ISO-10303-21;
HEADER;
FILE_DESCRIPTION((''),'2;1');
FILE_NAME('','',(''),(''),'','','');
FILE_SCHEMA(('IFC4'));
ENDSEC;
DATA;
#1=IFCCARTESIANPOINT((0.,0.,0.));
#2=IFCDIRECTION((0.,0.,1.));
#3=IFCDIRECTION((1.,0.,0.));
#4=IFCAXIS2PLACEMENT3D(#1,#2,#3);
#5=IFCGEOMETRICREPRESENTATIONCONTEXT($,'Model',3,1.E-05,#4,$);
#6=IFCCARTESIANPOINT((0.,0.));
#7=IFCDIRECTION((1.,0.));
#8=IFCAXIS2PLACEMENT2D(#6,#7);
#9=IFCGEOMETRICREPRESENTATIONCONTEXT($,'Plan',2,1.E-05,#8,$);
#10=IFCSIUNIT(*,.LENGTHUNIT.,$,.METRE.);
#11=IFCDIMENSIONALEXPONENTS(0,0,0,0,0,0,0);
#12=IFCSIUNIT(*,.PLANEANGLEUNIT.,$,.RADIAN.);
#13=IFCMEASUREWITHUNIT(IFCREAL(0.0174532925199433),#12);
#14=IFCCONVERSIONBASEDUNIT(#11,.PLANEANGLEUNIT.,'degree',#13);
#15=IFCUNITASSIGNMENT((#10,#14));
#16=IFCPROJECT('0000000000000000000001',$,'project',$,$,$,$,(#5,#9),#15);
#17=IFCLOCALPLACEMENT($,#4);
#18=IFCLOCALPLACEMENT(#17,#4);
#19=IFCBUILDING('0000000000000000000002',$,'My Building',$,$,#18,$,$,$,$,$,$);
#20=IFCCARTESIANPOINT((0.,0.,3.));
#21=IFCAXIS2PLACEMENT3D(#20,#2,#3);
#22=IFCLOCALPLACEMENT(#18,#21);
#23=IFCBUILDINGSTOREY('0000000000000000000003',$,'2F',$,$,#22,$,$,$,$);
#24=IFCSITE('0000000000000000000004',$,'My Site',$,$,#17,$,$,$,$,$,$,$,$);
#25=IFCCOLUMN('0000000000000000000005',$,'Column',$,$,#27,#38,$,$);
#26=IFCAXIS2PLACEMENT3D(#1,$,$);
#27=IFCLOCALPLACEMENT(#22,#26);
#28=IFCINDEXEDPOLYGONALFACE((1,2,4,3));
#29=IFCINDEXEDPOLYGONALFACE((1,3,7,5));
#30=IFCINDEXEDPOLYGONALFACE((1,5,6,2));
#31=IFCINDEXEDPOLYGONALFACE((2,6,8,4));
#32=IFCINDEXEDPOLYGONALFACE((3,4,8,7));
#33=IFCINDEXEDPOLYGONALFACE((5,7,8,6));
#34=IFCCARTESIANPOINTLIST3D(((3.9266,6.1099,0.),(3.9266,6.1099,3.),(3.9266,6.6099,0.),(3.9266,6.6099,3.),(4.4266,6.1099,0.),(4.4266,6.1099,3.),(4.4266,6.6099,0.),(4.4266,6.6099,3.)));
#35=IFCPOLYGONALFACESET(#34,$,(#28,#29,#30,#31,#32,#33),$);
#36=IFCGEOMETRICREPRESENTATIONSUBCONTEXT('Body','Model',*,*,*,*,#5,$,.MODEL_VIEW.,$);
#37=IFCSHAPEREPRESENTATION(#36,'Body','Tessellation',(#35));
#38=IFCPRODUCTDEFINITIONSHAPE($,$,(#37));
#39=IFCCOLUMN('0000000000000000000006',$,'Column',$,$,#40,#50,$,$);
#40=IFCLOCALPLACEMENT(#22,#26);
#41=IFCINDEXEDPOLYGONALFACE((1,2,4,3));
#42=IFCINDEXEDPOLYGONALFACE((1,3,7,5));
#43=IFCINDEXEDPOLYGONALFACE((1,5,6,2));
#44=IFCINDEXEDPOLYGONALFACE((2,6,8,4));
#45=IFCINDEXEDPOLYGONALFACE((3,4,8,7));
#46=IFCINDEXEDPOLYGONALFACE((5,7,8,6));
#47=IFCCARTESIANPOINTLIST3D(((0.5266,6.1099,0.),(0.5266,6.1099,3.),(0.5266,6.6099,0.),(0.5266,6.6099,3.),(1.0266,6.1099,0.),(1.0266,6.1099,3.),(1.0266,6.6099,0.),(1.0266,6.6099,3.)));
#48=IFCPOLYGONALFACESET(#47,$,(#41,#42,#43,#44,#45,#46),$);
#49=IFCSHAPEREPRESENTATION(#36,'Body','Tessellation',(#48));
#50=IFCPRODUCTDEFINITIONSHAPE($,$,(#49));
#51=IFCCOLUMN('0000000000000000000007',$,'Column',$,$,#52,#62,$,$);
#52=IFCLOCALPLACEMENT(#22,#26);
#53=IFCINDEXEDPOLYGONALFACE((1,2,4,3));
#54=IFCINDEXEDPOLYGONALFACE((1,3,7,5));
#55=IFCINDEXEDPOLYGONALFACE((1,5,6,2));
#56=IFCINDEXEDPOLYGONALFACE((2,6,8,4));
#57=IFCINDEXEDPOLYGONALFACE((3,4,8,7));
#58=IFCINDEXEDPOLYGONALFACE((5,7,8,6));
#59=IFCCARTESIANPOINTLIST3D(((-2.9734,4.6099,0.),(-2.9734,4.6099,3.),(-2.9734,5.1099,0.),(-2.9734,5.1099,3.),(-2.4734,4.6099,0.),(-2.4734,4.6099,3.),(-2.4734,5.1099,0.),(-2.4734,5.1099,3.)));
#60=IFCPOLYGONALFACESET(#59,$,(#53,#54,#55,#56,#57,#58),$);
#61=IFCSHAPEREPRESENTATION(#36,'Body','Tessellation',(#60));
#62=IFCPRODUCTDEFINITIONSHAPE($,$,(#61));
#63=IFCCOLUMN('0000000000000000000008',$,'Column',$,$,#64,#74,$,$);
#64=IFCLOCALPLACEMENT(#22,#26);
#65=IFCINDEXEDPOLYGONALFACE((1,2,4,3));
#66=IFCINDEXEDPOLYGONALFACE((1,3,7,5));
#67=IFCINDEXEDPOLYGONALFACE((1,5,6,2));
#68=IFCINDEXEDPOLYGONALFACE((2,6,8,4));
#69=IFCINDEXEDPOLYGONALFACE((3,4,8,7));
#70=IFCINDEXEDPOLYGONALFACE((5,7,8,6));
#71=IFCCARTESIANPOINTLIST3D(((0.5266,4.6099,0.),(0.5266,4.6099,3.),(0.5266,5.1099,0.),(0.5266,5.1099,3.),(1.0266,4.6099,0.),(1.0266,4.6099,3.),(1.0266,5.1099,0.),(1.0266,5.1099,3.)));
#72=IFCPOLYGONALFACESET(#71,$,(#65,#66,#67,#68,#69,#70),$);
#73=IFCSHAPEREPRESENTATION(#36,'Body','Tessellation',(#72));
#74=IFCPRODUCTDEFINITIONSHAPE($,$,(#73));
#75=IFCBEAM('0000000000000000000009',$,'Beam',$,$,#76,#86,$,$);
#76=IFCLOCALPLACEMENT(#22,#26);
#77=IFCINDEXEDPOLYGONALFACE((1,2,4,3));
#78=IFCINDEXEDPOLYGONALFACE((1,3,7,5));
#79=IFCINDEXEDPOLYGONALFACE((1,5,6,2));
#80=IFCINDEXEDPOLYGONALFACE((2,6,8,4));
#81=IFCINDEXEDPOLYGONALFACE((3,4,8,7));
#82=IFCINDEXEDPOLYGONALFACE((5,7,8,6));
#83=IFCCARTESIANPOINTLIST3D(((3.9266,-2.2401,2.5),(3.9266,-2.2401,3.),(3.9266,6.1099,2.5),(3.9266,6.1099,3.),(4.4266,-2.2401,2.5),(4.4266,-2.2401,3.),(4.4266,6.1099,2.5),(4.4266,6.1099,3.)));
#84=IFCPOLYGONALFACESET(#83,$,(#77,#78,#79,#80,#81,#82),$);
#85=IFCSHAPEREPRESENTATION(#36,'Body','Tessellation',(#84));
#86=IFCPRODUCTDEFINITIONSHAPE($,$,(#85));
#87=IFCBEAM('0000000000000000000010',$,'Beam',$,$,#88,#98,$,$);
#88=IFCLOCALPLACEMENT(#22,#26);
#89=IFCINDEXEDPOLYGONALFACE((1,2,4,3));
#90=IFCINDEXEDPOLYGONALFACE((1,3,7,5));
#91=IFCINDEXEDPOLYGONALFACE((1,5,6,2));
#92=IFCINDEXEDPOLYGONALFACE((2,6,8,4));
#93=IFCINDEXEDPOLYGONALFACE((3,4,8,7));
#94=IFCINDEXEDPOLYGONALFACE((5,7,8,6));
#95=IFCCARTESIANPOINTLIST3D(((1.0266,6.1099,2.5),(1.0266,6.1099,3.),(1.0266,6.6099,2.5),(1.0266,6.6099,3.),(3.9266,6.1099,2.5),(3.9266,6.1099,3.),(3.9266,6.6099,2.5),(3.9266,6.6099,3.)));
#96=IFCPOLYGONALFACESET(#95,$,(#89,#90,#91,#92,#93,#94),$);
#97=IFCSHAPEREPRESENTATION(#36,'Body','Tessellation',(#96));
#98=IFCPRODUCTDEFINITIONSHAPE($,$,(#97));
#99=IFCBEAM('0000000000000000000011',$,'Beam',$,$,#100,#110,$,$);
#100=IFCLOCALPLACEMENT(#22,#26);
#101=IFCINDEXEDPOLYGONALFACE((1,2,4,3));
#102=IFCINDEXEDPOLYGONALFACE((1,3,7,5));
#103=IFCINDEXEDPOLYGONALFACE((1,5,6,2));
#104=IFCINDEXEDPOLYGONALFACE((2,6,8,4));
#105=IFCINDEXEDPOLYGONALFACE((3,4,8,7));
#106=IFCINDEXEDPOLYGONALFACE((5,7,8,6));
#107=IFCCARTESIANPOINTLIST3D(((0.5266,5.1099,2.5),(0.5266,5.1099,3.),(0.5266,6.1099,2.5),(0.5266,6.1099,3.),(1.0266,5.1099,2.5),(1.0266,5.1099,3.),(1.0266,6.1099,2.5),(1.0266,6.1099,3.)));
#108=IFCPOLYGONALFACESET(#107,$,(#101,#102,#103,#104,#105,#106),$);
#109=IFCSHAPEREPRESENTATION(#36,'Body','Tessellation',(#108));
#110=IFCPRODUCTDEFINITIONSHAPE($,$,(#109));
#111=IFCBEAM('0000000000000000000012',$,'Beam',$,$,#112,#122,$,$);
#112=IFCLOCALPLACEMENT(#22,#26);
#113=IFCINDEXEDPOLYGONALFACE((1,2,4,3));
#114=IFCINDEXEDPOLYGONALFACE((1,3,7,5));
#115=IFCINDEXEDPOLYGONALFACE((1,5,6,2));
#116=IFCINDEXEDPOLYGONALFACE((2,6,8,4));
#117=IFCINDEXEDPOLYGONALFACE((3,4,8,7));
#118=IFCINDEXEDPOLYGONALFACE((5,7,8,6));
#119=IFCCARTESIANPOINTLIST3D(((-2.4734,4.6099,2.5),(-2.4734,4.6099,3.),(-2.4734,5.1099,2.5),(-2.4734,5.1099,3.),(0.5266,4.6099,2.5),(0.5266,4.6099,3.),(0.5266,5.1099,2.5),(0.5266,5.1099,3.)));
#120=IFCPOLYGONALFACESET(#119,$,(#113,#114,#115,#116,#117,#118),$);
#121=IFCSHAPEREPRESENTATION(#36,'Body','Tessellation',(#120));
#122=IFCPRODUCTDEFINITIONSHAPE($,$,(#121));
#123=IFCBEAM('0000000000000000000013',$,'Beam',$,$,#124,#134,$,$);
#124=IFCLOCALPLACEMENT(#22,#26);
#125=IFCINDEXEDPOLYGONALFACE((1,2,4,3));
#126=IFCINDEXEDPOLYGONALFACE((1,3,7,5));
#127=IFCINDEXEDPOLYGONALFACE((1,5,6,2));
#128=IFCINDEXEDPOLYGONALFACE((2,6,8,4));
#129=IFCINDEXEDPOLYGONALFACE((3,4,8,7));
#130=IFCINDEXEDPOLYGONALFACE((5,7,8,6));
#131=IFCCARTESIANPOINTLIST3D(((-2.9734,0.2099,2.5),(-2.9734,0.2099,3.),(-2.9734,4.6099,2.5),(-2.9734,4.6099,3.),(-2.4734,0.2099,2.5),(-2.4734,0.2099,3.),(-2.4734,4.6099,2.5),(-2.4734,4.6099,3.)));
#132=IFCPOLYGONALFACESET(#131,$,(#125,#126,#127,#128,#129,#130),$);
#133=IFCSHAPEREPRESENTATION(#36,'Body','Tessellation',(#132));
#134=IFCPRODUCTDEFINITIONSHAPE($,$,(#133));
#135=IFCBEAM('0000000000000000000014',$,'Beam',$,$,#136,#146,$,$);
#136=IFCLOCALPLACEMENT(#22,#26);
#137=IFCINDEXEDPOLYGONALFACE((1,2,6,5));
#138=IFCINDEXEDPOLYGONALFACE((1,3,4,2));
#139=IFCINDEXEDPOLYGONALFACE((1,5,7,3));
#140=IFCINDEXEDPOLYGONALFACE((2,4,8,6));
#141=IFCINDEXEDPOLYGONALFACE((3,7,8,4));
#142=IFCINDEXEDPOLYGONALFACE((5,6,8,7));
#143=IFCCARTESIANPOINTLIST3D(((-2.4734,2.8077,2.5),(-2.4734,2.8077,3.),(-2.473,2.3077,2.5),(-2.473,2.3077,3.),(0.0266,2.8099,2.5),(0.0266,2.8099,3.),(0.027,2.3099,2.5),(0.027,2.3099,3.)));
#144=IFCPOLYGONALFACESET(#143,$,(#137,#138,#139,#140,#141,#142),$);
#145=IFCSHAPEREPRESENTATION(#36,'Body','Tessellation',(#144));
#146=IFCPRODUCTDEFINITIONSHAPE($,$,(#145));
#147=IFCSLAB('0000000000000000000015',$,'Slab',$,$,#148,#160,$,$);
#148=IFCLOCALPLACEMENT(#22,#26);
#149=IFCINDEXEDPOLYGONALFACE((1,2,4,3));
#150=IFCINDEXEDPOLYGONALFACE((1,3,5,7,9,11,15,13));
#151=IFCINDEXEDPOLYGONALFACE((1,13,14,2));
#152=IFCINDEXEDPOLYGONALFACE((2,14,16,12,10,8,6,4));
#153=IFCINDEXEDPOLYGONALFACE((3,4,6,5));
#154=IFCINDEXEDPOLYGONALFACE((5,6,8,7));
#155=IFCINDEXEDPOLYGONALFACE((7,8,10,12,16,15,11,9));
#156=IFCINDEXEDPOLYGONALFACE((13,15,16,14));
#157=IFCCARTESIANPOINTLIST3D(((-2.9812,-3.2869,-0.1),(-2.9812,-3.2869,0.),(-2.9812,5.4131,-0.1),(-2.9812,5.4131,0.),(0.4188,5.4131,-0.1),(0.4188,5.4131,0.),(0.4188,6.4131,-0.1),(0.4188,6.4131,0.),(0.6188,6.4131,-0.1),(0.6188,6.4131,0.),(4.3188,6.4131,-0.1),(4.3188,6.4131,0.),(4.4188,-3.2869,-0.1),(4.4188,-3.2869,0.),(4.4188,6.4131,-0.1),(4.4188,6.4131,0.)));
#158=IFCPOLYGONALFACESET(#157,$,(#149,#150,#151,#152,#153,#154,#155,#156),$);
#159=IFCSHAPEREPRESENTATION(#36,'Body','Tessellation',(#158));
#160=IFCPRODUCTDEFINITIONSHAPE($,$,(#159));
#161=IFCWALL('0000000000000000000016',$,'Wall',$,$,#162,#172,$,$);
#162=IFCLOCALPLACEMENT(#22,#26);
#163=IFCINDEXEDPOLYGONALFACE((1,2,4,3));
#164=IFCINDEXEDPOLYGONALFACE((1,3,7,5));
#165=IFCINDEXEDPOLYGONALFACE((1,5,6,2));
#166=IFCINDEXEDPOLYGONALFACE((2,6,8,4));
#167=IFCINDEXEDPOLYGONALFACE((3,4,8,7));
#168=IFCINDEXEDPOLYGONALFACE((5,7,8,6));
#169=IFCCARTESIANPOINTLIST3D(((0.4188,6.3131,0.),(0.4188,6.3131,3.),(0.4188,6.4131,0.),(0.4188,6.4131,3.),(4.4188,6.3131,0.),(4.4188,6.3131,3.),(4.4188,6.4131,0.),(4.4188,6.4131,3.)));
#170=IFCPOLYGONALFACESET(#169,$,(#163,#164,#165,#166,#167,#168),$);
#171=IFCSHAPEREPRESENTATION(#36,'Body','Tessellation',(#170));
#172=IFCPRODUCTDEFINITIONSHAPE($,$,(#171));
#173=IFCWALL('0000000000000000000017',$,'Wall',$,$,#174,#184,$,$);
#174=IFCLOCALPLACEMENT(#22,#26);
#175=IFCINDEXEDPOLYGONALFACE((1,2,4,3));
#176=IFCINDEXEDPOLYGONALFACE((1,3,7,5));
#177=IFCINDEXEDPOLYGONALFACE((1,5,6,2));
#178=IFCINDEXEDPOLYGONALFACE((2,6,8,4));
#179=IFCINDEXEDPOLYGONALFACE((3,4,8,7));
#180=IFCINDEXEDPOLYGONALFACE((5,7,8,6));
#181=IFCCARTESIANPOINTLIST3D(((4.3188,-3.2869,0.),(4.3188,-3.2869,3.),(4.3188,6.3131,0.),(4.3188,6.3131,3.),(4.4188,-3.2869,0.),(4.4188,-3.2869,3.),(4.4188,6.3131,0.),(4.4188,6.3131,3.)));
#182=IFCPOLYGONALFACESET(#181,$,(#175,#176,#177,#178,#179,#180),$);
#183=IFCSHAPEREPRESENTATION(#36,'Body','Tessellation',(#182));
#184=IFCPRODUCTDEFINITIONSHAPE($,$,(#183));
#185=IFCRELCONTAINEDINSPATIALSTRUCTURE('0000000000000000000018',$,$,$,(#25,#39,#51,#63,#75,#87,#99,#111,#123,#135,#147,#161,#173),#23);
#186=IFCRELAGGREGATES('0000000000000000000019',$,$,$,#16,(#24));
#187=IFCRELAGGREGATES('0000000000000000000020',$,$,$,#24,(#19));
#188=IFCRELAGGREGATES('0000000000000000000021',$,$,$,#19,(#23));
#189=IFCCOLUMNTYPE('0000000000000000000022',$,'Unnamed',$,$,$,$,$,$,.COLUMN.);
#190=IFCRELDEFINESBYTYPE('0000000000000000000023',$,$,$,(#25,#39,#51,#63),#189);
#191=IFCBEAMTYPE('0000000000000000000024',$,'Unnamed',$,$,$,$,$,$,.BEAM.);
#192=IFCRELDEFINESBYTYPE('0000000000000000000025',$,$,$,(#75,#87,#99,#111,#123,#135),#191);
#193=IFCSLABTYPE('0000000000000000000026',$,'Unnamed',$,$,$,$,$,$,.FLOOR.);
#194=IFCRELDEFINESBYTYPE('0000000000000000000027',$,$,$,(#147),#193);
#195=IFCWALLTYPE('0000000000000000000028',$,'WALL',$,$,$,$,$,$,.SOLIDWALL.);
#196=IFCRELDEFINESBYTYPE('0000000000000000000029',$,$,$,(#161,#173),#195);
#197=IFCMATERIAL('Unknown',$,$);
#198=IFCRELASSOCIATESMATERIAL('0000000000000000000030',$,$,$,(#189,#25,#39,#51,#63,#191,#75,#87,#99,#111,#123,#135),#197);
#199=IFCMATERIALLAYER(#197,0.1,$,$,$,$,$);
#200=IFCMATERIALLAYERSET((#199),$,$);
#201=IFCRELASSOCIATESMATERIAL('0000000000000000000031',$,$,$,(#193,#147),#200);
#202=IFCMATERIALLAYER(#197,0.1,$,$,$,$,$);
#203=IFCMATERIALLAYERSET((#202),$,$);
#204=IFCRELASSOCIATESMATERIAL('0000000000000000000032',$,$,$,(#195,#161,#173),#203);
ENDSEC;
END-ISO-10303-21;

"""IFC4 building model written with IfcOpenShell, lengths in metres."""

from ifc_helpers import new_model, entity, si_unit, converted_unit, frame, origin_with_axes, origin_2d_with_axis, place, context, subcontext, project, spatial, line, indexed_curve, rectangle, outline, extrude, material, layer, layer_set, layer_usage, material_profile, profile_set, profile_usage, type_object, element, save


model = new_model("IFC4")

# Units and contexts
model_context = context("Model", 3, precision=1e-05, world=origin_with_axes())
plan_context = context("Plan", 2, precision=1e-05, world=origin_2d_with_axis())
body_context_1 = subcontext(model_context, "Body", "Model", "MODEL_VIEW")
ifc_project = project(units=[si_unit("LENGTHUNIT", "METRE"), converted_unit("PLANEANGLEUNIT", "degree", entity("IfcReal", 0.0174532925199433), si_unit("PLANEANGLEUNIT", "RADIAN"), dimensions=[0, 0, 0, 0, 0, 0, 0])], contexts=[model_context, plan_context])

# Site, building, storey
site_placement = place(None, origin_with_axes())
site = spatial("IfcSite", under=ifc_project, at=site_placement, Name="My Site")
building_placement = place(site_placement, origin_with_axes())
building = spatial("IfcBuilding", under=site, at=building_placement, Name="My Building")
storey_placement = place(building_placement, frame((0.0, 0.0, 3.0), z_axis=(0.0, 0.0, 1.0), x_axis=(1.0, 0.0, 0.0)))
storey = spatial("IfcBuildingStorey", under=building, at=storey_placement, Name="2F")

# Columns
ifc_material = material(Name="Unknown")
ifc_material_profile_1 = material_profile(ifc_material, rectangle(XDim=0.5, YDim=0.5))
ifc_profile_set_1 = profile_set([ifc_material_profile_1])
ifc_profile_usage_1 = profile_usage(ifc_profile_set_1, cardinal=5)
column_type = type_object("IfcColumnType", Name="Unnamed", PredefinedType="COLUMN", material=ifc_profile_set_1)
column_1_placement = place(storey_placement, frame((4.1766, 6.3599, 0.0), z_axis=(0.0, 0.0, 1.0), x_axis=(1.0, 0.0, 0.0)))
element("IfcColumn", 1, at=column_1_placement, inside=storey, type_object=column_type, material=ifc_profile_usage_1, Name="Column", context=body_context_1, shape_type="SweptSolid", body=[
    extrude(rectangle(XDim=0.5, YDim=0.5), origin_with_axes(), (0.0, 0.0, 1.0), 3.0),
])
ifc_profile_usage_2 = profile_usage(ifc_profile_set_1, cardinal=5)
column_2_placement = place(storey_placement, frame((0.7766, 6.3599, 0.0), z_axis=(0.0, 0.0, 1.0), x_axis=(1.0, 0.0, 0.0)))
element("IfcColumn", 2, at=column_2_placement, inside=storey, type_object=column_type, material=ifc_profile_usage_2, Name="Column", context=body_context_1, shape_type="SweptSolid", body=[
    extrude(rectangle(XDim=0.5, YDim=0.5), origin_with_axes(), (0.0, 0.0, 1.0), 3.0),
])
ifc_profile_usage_3 = profile_usage(ifc_profile_set_1, cardinal=5)
column_3_placement = place(storey_placement, frame((-2.7234, 4.8599, 0.0), z_axis=(0.0, 0.0, 1.0), x_axis=(1.0, 0.0, 0.0)))
element("IfcColumn", 3, at=column_3_placement, inside=storey, type_object=column_type, material=ifc_profile_usage_3, Name="Column", context=body_context_1, shape_type="SweptSolid", body=[
    extrude(rectangle(XDim=0.5, YDim=0.5), origin_with_axes(), (0.0, 0.0, 1.0), 3.0),
])
ifc_profile_usage_4 = profile_usage(ifc_profile_set_1, cardinal=5)
column_4_placement = place(storey_placement, frame((0.7766, 4.8599, 0.0), z_axis=(0.0, 0.0, 1.0), x_axis=(1.0, 0.0, 0.0)))
element("IfcColumn", 4, at=column_4_placement, inside=storey, type_object=column_type, material=ifc_profile_usage_4, Name="Column", context=body_context_1, shape_type="SweptSolid", body=[
    extrude(rectangle(XDim=0.5, YDim=0.5), origin_with_axes(), (0.0, 0.0, 1.0), 3.0),
])

# Beams
ifc_material_profile_2 = material_profile(ifc_material, rectangle(XDim=0.5, YDim=0.5))
ifc_profile_set_2 = profile_set([ifc_material_profile_2])
ifc_profile_usage_5 = profile_usage(ifc_profile_set_2, cardinal=9)
beam_type = type_object("IfcBeamType", Name="Unnamed", PredefinedType="BEAM", material=ifc_profile_set_2)
beam_1_placement = place(storey_placement, frame((3.9266, 6.1099, 3.0), z_axis=(0.0, -1.0, 0.0), x_axis=(1.0, 0.0, 0.0)))
element("IfcBeam", 5, at=beam_1_placement, inside=storey, type_object=beam_type, material=ifc_profile_usage_5, Name="Beam", context=body_context_1, shape_type="SweptSolid", body=[
    extrude(rectangle(XDim=0.5, YDim=0.5), frame((0.25, -0.25, 0.0), z_axis=(0.0, 0.0, 1.0), x_axis=(1.0, 0.0, 0.0)), (0.0, 0.0, 1.0), 8.35),
])
ifc_profile_usage_6 = profile_usage(ifc_profile_set_2, cardinal=7)
beam_2_placement = place(storey_placement, frame((1.0266, 6.6099, 3.0), z_axis=(1.0, -0.000001, 0.0), x_axis=(0.000001, 1.0, 0.0)))
element("IfcBeam", 6, at=beam_2_placement, inside=storey, type_object=beam_type, material=ifc_profile_usage_6, Name="Beam", context=body_context_1, shape_type="SweptSolid", body=[
    extrude(rectangle(XDim=0.5, YDim=0.5), frame((-0.25, -0.25, 0.0), z_axis=(0.0, 0.0, 1.0), x_axis=(1.0, 0.0, 0.0)), (0.0, 0.0, 1.0), 2.9),
])
ifc_profile_usage_7 = profile_usage(ifc_profile_set_2, cardinal=7)
beam_3_placement = place(storey_placement, frame((1.0266, 6.1099, 3.0), z_axis=(0.0, -1.0, 0.0), x_axis=(1.0, 0.0, 0.0)))
element("IfcBeam", 7, at=beam_3_placement, inside=storey, type_object=beam_type, material=ifc_profile_usage_7, Name="Beam", context=body_context_1, shape_type="SweptSolid", body=[
    extrude(rectangle(XDim=0.5, YDim=0.5), frame((-0.25, -0.25, 0.0), z_axis=(0.0, 0.0, 1.0), x_axis=(1.0, 0.0, 0.0)), (0.0, 0.0, 1.0), 1.0),
])
ifc_profile_usage_8 = profile_usage(ifc_profile_set_2, cardinal=7)
beam_4_placement = place(storey_placement, frame((-2.4734, 5.1099, 3.0), z_axis=(1.0, -0.000001, 0.0), x_axis=(0.000001, 1.0, 0.0)))
element("IfcBeam", 8, at=beam_4_placement, inside=storey, type_object=beam_type, material=ifc_profile_usage_8, Name="Beam", context=body_context_1, shape_type="SweptSolid", body=[
    extrude(rectangle(XDim=0.5, YDim=0.5), frame((-0.25, -0.25, 0.0), z_axis=(0.0, 0.0, 1.0), x_axis=(1.0, 0.0, 0.0)), (0.0, 0.0, 1.0), 3.0),
])
ifc_profile_usage_9 = profile_usage(ifc_profile_set_2, cardinal=7)
beam_5_placement = place(storey_placement, frame((-2.4734, 4.6099, 3.0), z_axis=(0.0, -1.0, 0.0), x_axis=(1.0, 0.0, 0.0)))
element("IfcBeam", 9, at=beam_5_placement, inside=storey, type_object=beam_type, material=ifc_profile_usage_9, Name="Beam", context=body_context_1, shape_type="SweptSolid", body=[
    extrude(rectangle(XDim=0.5, YDim=0.5), frame((-0.25, -0.25, 0.0), z_axis=(0.0, 0.0, 1.0), x_axis=(1.0, 0.0, 0.0)), (0.0, 0.0, 1.0), 4.4),
])
ifc_profile_usage_10 = profile_usage(ifc_profile_set_2, cardinal=7)
beam_6_placement = place(storey_placement, frame((-2.4734, 2.8077, 3.0), z_axis=(1.0, 0.000853, 0.0), x_axis=(-0.000853, 1.0, 0.0)))
element("IfcBeam", 10, at=beam_6_placement, inside=storey, type_object=beam_type, material=ifc_profile_usage_10, Name="Beam", context=body_context_1, shape_type="SweptSolid", body=[
    extrude(rectangle(XDim=0.5, YDim=0.5), frame((-0.25, -0.25, 0.0), z_axis=(0.0, 0.0, 1.0), x_axis=(1.0, 0.0, 0.0)), (0.0, 0.0, 1.0), 2.5),
])

# Slab
ifc_layer_1 = layer(ifc_material, 0.1)
ifc_layer_set_1 = layer_set([ifc_layer_1])
ifc_layer_usage_1 = layer_usage(ifc_layer_set_1, "AXIS3", "POSITIVE", -0.1)
slab_type = type_object("IfcSlabType", Name="Unnamed", PredefinedType="FLOOR", material=ifc_layer_set_1)
slab_placement = place(storey_placement, frame((0.6188, 6.4131, 0.0), z_axis=(0.0, 0.0, 1.0), x_axis=(1.0, 0.0, 0.0)))
element("IfcSlab", 11, at=slab_placement, inside=storey, type_object=slab_type, material=ifc_layer_usage_1, Name="Slab", context=body_context_1, shape_type="SweptSolid", body=[
    extrude(outline(indexed_curve([(0.0, 0.0), (3.7, 0.0), (3.8, 0.0), (3.8, -9.7), (-3.6, -9.7), (-3.6, -1.0), (-0.2, -1.0), (-0.2, 0.0), (0.0, 0.0)])), frame((0.0, 0.0, -0.1), z_axis=(0.0, 0.0, 1.0), x_axis=(1.0, 0.0, 0.0)), (0.0, 0.0, 1.0), 0.1),
])

# Walls
ifc_layer_2 = layer(ifc_material, 0.1)
ifc_layer_set_2 = layer_set([ifc_layer_2])
ifc_layer_usage_2 = layer_usage(ifc_layer_set_2, "AXIS2", "POSITIVE", 0.0)
wall_type = type_object("IfcWallType", Name="WALL", PredefinedType="SOLIDWALL", material=ifc_layer_set_2)
wall_1_placement = place(storey_placement, frame((0.4188, 6.3131, 0.0), z_axis=(0.0, 0.0, 1.0), x_axis=(1.0, 0.0, 0.0)))
element("IfcWall", 12, at=wall_1_placement, inside=storey, type_object=wall_type, material=ifc_layer_usage_2, Name="Wall", context=body_context_1, shape_type="SweptSolid", body=[
    extrude(outline(indexed_curve([(0.0, 0.0), (0.0, 0.1), (4.0, 0.1), (4.0, 0.0)], segments=[line(1, 2, 3, 4, 1)])), origin_with_axes(), (0.0, 0.0, 1.0), 3.0),
])
ifc_layer_usage_3 = layer_usage(ifc_layer_set_2, "AXIS2", "POSITIVE", 0.0)
wall_2_placement = place(storey_placement, frame((4.3188, 6.3131, 0.0), z_axis=(0.0, 0.0, 1.0), x_axis=(0.0, -1.0, 0.0)))
element("IfcWall", 13, at=wall_2_placement, inside=storey, type_object=wall_type, material=ifc_layer_usage_3, Name="Wall", context=body_context_1, shape_type="SweptSolid", body=[
    extrude(outline(indexed_curve([(0.0, 0.0), (0.0, 0.1), (9.6, 0.1), (9.6, 0.0)], segments=[line(1, 2, 3, 4, 1)])), origin_with_axes(), (0.0, 0.0, 1.0), 3.0),
])

save(model, "model.ifc")
